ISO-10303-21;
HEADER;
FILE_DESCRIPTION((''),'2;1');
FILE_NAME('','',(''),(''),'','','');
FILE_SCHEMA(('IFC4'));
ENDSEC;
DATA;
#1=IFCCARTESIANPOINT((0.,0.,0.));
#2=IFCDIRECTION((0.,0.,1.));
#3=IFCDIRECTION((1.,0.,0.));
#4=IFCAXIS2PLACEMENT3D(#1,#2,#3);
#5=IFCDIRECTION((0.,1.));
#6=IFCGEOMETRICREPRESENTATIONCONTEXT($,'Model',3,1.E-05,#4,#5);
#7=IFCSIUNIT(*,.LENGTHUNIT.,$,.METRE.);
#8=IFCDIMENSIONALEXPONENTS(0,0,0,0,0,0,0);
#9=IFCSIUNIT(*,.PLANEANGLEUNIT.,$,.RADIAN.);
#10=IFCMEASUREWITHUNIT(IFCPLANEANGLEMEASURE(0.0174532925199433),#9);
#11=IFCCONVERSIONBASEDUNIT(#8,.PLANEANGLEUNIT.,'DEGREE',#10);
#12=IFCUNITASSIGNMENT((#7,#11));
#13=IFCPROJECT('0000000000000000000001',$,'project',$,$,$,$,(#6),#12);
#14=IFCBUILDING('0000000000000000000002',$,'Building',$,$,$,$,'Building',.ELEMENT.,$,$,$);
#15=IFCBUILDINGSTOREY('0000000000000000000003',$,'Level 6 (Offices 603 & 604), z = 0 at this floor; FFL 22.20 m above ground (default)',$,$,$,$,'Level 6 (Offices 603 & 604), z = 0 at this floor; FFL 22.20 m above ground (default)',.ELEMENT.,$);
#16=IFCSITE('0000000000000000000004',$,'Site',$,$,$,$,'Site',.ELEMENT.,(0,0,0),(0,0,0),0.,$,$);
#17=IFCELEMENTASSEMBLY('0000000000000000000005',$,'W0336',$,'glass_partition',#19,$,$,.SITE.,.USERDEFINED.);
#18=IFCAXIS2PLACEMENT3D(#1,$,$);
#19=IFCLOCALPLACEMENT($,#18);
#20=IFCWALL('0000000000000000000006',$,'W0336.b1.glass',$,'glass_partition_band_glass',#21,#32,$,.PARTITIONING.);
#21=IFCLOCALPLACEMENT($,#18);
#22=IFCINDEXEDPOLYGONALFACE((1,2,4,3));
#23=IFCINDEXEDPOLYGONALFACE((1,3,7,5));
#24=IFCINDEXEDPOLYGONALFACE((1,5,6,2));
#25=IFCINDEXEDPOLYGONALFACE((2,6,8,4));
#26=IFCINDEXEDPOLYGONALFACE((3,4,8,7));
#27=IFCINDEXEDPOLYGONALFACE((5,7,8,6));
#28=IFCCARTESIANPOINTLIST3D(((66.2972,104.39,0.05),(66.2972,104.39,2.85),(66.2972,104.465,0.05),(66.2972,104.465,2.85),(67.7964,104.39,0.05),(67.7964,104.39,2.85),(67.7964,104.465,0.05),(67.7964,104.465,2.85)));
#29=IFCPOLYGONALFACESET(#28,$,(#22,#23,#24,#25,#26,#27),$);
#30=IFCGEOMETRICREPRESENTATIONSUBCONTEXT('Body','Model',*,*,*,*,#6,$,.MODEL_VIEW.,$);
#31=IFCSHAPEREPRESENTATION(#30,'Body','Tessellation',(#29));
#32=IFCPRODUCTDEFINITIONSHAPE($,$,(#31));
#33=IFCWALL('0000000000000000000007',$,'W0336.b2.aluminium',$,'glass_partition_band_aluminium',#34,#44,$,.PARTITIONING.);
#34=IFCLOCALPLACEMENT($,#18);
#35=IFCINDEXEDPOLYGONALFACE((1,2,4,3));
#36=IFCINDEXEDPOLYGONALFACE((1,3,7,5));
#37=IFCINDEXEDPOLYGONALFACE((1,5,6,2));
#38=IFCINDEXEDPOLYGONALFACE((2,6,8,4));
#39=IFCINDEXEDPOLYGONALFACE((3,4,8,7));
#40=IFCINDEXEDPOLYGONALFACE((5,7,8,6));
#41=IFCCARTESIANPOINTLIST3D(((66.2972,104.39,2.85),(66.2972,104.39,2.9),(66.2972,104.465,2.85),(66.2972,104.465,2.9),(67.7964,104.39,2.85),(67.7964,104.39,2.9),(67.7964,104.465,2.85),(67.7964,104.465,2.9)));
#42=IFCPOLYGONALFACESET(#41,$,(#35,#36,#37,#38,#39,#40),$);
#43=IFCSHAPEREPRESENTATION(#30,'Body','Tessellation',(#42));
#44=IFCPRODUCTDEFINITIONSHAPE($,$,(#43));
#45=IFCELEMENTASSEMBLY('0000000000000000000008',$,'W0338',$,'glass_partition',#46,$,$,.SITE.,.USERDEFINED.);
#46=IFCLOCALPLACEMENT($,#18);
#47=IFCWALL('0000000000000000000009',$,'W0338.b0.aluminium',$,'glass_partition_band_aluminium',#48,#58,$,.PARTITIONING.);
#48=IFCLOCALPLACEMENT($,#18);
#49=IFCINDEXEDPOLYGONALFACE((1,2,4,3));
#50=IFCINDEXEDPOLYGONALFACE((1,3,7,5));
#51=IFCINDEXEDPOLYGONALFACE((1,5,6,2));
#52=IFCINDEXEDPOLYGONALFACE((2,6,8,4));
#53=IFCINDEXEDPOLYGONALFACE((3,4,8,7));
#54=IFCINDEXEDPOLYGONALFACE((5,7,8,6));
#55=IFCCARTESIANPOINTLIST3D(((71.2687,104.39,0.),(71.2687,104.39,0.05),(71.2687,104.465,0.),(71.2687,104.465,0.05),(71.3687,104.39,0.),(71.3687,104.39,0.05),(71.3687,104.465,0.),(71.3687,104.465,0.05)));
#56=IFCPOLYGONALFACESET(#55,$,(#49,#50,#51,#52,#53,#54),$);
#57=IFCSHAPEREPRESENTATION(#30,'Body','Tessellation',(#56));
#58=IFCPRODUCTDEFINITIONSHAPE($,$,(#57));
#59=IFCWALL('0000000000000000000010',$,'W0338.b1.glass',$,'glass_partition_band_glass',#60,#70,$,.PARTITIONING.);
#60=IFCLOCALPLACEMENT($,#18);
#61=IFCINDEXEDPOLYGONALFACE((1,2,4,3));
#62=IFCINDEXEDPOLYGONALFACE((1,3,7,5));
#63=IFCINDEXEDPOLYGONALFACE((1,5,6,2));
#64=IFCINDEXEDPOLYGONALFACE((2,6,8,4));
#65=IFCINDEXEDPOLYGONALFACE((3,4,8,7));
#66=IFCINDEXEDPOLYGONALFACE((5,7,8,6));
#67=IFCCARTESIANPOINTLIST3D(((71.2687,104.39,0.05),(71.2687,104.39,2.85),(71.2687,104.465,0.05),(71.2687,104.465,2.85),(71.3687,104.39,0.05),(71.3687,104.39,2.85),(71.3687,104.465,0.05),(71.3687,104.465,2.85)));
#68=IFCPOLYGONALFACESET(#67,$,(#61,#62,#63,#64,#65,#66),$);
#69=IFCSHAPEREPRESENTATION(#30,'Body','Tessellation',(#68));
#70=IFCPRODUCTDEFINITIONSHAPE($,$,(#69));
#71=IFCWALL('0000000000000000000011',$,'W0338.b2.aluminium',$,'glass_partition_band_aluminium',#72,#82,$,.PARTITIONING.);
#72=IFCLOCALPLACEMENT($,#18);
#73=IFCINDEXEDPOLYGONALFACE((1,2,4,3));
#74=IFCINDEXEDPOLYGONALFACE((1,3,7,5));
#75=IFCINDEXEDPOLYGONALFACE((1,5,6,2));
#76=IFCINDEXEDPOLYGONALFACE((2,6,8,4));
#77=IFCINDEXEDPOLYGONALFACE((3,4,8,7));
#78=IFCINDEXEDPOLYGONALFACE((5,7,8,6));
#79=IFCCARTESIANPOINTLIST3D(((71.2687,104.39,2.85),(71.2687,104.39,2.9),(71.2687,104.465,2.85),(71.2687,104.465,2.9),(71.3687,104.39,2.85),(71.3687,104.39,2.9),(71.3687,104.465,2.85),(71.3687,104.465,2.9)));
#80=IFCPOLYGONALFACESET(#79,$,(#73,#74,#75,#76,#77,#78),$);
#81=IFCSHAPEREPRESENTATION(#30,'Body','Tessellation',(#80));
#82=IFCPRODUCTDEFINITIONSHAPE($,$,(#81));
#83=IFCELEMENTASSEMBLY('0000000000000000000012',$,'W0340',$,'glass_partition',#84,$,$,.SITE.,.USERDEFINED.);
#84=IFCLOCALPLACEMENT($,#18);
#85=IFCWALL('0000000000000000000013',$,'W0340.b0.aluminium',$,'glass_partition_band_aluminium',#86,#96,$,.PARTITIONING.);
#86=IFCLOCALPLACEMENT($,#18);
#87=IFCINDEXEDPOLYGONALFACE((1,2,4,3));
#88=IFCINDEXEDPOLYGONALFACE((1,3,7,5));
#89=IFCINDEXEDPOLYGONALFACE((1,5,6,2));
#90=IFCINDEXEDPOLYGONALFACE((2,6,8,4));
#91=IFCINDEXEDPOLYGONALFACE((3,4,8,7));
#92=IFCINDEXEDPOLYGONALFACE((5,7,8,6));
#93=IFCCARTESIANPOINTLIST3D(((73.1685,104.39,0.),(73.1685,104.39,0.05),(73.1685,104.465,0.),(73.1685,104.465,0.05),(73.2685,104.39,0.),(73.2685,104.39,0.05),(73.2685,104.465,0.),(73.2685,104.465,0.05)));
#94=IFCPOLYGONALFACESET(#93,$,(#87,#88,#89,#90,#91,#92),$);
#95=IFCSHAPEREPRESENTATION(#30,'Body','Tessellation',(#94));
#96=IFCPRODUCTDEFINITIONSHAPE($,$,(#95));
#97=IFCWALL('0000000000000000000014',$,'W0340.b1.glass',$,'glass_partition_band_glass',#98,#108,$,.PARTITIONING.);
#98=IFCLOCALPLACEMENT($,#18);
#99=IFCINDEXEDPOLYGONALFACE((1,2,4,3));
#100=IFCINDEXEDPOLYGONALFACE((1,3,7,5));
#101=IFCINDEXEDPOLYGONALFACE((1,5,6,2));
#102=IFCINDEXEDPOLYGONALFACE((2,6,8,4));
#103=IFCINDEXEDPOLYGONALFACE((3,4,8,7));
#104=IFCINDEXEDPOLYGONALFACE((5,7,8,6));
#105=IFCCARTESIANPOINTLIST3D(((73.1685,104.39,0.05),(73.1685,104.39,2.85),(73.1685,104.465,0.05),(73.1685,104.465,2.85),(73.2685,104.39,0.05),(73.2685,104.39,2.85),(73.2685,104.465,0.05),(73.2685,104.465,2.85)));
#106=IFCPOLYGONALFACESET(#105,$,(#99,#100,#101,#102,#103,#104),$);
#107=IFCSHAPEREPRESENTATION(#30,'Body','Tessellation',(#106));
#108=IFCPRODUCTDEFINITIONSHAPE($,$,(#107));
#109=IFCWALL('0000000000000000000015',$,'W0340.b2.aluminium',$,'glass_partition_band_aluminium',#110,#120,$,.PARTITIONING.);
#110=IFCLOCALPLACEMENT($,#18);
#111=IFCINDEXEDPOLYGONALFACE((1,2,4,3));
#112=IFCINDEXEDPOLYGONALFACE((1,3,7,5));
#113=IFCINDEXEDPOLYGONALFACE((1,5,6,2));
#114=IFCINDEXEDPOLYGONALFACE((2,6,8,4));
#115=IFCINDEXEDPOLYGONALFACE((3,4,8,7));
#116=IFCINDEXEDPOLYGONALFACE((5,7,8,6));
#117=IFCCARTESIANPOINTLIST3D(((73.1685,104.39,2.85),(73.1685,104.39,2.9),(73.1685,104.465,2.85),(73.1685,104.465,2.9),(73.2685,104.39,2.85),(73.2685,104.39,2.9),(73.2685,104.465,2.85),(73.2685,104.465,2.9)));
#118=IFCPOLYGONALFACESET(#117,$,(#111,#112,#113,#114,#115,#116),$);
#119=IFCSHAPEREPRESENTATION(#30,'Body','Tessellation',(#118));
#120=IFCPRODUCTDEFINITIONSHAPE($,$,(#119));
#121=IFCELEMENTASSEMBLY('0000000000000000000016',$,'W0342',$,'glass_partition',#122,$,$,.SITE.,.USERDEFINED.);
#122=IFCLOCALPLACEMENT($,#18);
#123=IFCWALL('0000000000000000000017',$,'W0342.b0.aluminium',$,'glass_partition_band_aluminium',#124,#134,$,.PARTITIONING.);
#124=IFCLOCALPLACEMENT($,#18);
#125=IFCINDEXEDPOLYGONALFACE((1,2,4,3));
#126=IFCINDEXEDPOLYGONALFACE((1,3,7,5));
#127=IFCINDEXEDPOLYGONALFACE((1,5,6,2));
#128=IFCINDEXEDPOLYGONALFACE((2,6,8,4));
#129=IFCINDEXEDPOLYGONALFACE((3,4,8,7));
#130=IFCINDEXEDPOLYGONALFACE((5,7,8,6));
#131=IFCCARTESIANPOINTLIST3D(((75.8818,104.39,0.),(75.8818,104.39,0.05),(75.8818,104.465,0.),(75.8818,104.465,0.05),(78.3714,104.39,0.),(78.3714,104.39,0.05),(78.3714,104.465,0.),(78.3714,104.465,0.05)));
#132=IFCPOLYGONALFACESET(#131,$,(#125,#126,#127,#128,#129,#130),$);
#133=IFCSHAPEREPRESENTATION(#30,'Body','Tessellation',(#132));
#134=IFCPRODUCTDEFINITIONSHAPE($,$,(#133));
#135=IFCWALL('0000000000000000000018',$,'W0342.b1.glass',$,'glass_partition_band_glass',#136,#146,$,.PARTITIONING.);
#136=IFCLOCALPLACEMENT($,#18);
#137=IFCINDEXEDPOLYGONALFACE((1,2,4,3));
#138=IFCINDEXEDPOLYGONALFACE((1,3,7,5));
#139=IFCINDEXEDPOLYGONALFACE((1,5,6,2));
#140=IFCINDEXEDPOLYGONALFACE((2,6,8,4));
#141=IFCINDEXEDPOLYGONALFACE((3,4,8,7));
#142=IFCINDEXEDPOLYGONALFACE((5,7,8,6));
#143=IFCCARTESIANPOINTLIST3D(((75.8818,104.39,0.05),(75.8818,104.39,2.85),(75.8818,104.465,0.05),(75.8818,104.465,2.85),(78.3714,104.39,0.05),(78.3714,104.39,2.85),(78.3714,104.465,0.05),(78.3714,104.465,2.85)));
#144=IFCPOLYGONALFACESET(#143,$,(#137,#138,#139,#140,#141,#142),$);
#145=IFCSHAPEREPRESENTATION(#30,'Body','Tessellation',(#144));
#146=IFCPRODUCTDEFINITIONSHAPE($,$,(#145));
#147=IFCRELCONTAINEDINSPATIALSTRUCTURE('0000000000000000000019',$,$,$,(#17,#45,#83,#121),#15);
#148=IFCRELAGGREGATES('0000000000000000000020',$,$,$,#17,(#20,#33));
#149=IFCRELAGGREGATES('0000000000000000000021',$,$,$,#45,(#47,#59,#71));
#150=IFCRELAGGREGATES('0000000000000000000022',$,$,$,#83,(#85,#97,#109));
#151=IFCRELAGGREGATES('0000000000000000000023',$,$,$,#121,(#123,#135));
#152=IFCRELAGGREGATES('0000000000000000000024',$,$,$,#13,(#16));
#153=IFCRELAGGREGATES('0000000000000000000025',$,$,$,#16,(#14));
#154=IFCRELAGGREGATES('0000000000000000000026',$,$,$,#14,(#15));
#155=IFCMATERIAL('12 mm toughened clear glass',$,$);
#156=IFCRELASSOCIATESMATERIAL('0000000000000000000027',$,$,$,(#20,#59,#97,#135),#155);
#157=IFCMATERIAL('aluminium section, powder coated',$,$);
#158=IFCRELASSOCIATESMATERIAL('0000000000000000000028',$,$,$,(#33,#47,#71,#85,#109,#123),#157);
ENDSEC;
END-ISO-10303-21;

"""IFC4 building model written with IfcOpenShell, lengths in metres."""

from ifc_helpers import new_model, entity, si_unit, converted_unit, direction, frame, frame_2d, origin_with_axes, place, context, subcontext, project, spatial, rectangle, extrude, material, element, aggregate, save


model = new_model("IFC4")

# Units and contexts
model_context = context("Model", 3, precision=1e-05, world=origin_with_axes(), true_north=direction((0.0, 1.0)))
body_context = subcontext(model_context, "Body", "Model", "MODEL_VIEW")
ifc_project = project(units=[si_unit("LENGTHUNIT", "METRE"), converted_unit("PLANEANGLEUNIT", "DEGREE", entity("IfcPlaneAngleMeasure", 0.0174532925199433), si_unit("PLANEANGLEUNIT", "RADIAN"), dimensions=[0, 0, 0, 0, 0, 0, 0])], contexts=[model_context])

# Site, building, storey
site = spatial("IfcSite", under=ifc_project, Name="Site", LongName="Site", CompositionType="ELEMENT", RefLatitude=(0, 0, 0), RefLongitude=(0, 0, 0), RefElevation=0.0)
building = spatial("IfcBuilding", under=site, Name="Building", LongName="Building", CompositionType="ELEMENT")
storey = spatial("IfcBuildingStorey", under=building, Name="Level 6 (Offices 603 & 604), z = 0 at this floor; FFL 22.20 m above ground (default)", LongName="Level 6 (Offices 603 & 604), z = 0 at this floor; FFL 22.20 m above ground (default)", CompositionType="ELEMENT")

# Shared definitions
placement = place(None, origin_with_axes())

# Element assemblies, walls
ifc_material_1 = material(Name="aluminium section, powder coated")
ifc_material_2 = material(Name="12 mm toughened clear glass")
assembly_1 = element("IfcElementAssembly", 1, inside=storey, Name="W0336", ObjectType="glass_partition", AssemblyPlace="SITE", PredefinedType="USERDEFINED")
wall_1 = element("IfcWall", 2, at=placement, material=ifc_material_2, Name="W0336.b1.glass", ObjectType="glass_partition_band_glass", PredefinedType="PARTITIONING", context=body_context, shape_type="SweptSolid", body=[
    extrude(rectangle(XDim=1.4992, YDim=0.075, at=frame_2d((0.0, 0.0), x_axis=(1.0, 0.0))), frame((67.0468, 104.4275, 0.05), z_axis=(0.0, 0.0, 1.0), x_axis=(1.0, 0.0, 0.0)), (0.0, 0.0, 1.0), 2.8),
])
wall_2 = element("IfcWall", 3, at=placement, material=ifc_material_1, Name="W0336.b2.aluminium", ObjectType="glass_partition_band_aluminium", PredefinedType="PARTITIONING", context=body_context, shape_type="SweptSolid", body=[
    extrude(rectangle(XDim=1.4992, YDim=0.075, at=frame_2d((0.0, 0.0), x_axis=(1.0, 0.0))), frame((67.0468, 104.4275, 2.85), z_axis=(0.0, 0.0, 1.0), x_axis=(1.0, 0.0, 0.0)), (0.0, 0.0, 1.0), 0.05),
])
aggregate(assembly_1, [wall_1, wall_2])
assembly_2 = element("IfcElementAssembly", 4, inside=storey, Name="W0338", ObjectType="glass_partition", AssemblyPlace="SITE", PredefinedType="USERDEFINED")
wall_3 = element("IfcWall", 5, at=placement, material=ifc_material_1, Name="W0338.b0.aluminium", ObjectType="glass_partition_band_aluminium", PredefinedType="PARTITIONING", context=body_context, shape_type="SweptSolid", body=[
    extrude(rectangle(XDim=0.1, YDim=0.075, at=frame_2d((0.0, 0.0), x_axis=(1.0, 0.0))), frame((71.3187, 104.4275, 0.0), z_axis=(0.0, 0.0, 1.0), x_axis=(1.0, 0.0, 0.0)), (0.0, 0.0, 1.0), 0.05),
])
wall_4 = element("IfcWall", 6, at=placement, material=ifc_material_2, Name="W0338.b1.glass", ObjectType="glass_partition_band_glass", PredefinedType="PARTITIONING", context=body_context, shape_type="SweptSolid", body=[
    extrude(rectangle(XDim=0.1, YDim=0.075, at=frame_2d((0.0, 0.0), x_axis=(1.0, 0.0))), frame((71.3187, 104.4275, 0.05), z_axis=(0.0, 0.0, 1.0), x_axis=(1.0, 0.0, 0.0)), (0.0, 0.0, 1.0), 2.8),
])
wall_5 = element("IfcWall", 7, at=placement, material=ifc_material_1, Name="W0338.b2.aluminium", ObjectType="glass_partition_band_aluminium", PredefinedType="PARTITIONING", context=body_context, shape_type="SweptSolid", body=[
    extrude(rectangle(XDim=0.1, YDim=0.075, at=frame_2d((0.0, 0.0), x_axis=(1.0, 0.0))), frame((71.3187, 104.4275, 2.85), z_axis=(0.0, 0.0, 1.0), x_axis=(1.0, 0.0, 0.0)), (0.0, 0.0, 1.0), 0.05),
])
aggregate(assembly_2, [wall_3, wall_4, wall_5])
assembly_3 = element("IfcElementAssembly", 8, inside=storey, Name="W0340", ObjectType="glass_partition", AssemblyPlace="SITE", PredefinedType="USERDEFINED")
wall_6 = element("IfcWall", 9, at=placement, material=ifc_material_1, Name="W0340.b0.aluminium", ObjectType="glass_partition_band_aluminium", PredefinedType="PARTITIONING", context=body_context, shape_type="SweptSolid", body=[
    extrude(rectangle(XDim=0.1, YDim=0.075, at=frame_2d((0.0, 0.0), x_axis=(1.0, 0.0))), frame((73.2185, 104.4275, 0.0), z_axis=(0.0, 0.0, 1.0), x_axis=(1.0, 0.0, 0.0)), (0.0, 0.0, 1.0), 0.05),
])
wall_7 = element("IfcWall", 10, at=placement, material=ifc_material_2, Name="W0340.b1.glass", ObjectType="glass_partition_band_glass", PredefinedType="PARTITIONING", context=body_context, shape_type="SweptSolid", body=[
    extrude(rectangle(XDim=0.1, YDim=0.075, at=frame_2d((0.0, 0.0), x_axis=(1.0, 0.0))), frame((73.2185, 104.4275, 0.05), z_axis=(0.0, 0.0, 1.0), x_axis=(1.0, 0.0, 0.0)), (0.0, 0.0, 1.0), 2.8),
])
wall_8 = element("IfcWall", 11, at=placement, material=ifc_material_1, Name="W0340.b2.aluminium", ObjectType="glass_partition_band_aluminium", PredefinedType="PARTITIONING", context=body_context, shape_type="SweptSolid", body=[
    extrude(rectangle(XDim=0.1, YDim=0.075, at=frame_2d((0.0, 0.0), x_axis=(1.0, 0.0))), frame((73.2185, 104.4275, 2.85), z_axis=(0.0, 0.0, 1.0), x_axis=(1.0, 0.0, 0.0)), (0.0, 0.0, 1.0), 0.05),
])
aggregate(assembly_3, [wall_6, wall_7, wall_8])
assembly_4 = element("IfcElementAssembly", 12, inside=storey, Name="W0342", ObjectType="glass_partition", AssemblyPlace="SITE", PredefinedType="USERDEFINED")
wall_9 = element("IfcWall", 13, at=placement, material=ifc_material_1, Name="W0342.b0.aluminium", ObjectType="glass_partition_band_aluminium", PredefinedType="PARTITIONING", context=body_context, shape_type="SweptSolid", body=[
    extrude(rectangle(XDim=2.4896, YDim=0.075, at=frame_2d((0.0, 0.0), x_axis=(1.0, 0.0))), frame((77.1266, 104.4275, 0.0), z_axis=(0.0, 0.0, 1.0), x_axis=(1.0, 0.0, 0.0)), (0.0, 0.0, 1.0), 0.05),
])
wall_10 = element("IfcWall", 14, at=placement, material=ifc_material_2, Name="W0342.b1.glass", ObjectType="glass_partition_band_glass", PredefinedType="PARTITIONING", context=body_context, shape_type="SweptSolid", body=[
    extrude(rectangle(XDim=2.4896, YDim=0.075, at=frame_2d((0.0, 0.0), x_axis=(1.0, 0.0))), frame((77.1266, 104.4275, 0.05), z_axis=(0.0, 0.0, 1.0), x_axis=(1.0, 0.0, 0.0)), (0.0, 0.0, 1.0), 2.8),
])
aggregate(assembly_4, [wall_9, wall_10])

save(model, "model.ifc")
